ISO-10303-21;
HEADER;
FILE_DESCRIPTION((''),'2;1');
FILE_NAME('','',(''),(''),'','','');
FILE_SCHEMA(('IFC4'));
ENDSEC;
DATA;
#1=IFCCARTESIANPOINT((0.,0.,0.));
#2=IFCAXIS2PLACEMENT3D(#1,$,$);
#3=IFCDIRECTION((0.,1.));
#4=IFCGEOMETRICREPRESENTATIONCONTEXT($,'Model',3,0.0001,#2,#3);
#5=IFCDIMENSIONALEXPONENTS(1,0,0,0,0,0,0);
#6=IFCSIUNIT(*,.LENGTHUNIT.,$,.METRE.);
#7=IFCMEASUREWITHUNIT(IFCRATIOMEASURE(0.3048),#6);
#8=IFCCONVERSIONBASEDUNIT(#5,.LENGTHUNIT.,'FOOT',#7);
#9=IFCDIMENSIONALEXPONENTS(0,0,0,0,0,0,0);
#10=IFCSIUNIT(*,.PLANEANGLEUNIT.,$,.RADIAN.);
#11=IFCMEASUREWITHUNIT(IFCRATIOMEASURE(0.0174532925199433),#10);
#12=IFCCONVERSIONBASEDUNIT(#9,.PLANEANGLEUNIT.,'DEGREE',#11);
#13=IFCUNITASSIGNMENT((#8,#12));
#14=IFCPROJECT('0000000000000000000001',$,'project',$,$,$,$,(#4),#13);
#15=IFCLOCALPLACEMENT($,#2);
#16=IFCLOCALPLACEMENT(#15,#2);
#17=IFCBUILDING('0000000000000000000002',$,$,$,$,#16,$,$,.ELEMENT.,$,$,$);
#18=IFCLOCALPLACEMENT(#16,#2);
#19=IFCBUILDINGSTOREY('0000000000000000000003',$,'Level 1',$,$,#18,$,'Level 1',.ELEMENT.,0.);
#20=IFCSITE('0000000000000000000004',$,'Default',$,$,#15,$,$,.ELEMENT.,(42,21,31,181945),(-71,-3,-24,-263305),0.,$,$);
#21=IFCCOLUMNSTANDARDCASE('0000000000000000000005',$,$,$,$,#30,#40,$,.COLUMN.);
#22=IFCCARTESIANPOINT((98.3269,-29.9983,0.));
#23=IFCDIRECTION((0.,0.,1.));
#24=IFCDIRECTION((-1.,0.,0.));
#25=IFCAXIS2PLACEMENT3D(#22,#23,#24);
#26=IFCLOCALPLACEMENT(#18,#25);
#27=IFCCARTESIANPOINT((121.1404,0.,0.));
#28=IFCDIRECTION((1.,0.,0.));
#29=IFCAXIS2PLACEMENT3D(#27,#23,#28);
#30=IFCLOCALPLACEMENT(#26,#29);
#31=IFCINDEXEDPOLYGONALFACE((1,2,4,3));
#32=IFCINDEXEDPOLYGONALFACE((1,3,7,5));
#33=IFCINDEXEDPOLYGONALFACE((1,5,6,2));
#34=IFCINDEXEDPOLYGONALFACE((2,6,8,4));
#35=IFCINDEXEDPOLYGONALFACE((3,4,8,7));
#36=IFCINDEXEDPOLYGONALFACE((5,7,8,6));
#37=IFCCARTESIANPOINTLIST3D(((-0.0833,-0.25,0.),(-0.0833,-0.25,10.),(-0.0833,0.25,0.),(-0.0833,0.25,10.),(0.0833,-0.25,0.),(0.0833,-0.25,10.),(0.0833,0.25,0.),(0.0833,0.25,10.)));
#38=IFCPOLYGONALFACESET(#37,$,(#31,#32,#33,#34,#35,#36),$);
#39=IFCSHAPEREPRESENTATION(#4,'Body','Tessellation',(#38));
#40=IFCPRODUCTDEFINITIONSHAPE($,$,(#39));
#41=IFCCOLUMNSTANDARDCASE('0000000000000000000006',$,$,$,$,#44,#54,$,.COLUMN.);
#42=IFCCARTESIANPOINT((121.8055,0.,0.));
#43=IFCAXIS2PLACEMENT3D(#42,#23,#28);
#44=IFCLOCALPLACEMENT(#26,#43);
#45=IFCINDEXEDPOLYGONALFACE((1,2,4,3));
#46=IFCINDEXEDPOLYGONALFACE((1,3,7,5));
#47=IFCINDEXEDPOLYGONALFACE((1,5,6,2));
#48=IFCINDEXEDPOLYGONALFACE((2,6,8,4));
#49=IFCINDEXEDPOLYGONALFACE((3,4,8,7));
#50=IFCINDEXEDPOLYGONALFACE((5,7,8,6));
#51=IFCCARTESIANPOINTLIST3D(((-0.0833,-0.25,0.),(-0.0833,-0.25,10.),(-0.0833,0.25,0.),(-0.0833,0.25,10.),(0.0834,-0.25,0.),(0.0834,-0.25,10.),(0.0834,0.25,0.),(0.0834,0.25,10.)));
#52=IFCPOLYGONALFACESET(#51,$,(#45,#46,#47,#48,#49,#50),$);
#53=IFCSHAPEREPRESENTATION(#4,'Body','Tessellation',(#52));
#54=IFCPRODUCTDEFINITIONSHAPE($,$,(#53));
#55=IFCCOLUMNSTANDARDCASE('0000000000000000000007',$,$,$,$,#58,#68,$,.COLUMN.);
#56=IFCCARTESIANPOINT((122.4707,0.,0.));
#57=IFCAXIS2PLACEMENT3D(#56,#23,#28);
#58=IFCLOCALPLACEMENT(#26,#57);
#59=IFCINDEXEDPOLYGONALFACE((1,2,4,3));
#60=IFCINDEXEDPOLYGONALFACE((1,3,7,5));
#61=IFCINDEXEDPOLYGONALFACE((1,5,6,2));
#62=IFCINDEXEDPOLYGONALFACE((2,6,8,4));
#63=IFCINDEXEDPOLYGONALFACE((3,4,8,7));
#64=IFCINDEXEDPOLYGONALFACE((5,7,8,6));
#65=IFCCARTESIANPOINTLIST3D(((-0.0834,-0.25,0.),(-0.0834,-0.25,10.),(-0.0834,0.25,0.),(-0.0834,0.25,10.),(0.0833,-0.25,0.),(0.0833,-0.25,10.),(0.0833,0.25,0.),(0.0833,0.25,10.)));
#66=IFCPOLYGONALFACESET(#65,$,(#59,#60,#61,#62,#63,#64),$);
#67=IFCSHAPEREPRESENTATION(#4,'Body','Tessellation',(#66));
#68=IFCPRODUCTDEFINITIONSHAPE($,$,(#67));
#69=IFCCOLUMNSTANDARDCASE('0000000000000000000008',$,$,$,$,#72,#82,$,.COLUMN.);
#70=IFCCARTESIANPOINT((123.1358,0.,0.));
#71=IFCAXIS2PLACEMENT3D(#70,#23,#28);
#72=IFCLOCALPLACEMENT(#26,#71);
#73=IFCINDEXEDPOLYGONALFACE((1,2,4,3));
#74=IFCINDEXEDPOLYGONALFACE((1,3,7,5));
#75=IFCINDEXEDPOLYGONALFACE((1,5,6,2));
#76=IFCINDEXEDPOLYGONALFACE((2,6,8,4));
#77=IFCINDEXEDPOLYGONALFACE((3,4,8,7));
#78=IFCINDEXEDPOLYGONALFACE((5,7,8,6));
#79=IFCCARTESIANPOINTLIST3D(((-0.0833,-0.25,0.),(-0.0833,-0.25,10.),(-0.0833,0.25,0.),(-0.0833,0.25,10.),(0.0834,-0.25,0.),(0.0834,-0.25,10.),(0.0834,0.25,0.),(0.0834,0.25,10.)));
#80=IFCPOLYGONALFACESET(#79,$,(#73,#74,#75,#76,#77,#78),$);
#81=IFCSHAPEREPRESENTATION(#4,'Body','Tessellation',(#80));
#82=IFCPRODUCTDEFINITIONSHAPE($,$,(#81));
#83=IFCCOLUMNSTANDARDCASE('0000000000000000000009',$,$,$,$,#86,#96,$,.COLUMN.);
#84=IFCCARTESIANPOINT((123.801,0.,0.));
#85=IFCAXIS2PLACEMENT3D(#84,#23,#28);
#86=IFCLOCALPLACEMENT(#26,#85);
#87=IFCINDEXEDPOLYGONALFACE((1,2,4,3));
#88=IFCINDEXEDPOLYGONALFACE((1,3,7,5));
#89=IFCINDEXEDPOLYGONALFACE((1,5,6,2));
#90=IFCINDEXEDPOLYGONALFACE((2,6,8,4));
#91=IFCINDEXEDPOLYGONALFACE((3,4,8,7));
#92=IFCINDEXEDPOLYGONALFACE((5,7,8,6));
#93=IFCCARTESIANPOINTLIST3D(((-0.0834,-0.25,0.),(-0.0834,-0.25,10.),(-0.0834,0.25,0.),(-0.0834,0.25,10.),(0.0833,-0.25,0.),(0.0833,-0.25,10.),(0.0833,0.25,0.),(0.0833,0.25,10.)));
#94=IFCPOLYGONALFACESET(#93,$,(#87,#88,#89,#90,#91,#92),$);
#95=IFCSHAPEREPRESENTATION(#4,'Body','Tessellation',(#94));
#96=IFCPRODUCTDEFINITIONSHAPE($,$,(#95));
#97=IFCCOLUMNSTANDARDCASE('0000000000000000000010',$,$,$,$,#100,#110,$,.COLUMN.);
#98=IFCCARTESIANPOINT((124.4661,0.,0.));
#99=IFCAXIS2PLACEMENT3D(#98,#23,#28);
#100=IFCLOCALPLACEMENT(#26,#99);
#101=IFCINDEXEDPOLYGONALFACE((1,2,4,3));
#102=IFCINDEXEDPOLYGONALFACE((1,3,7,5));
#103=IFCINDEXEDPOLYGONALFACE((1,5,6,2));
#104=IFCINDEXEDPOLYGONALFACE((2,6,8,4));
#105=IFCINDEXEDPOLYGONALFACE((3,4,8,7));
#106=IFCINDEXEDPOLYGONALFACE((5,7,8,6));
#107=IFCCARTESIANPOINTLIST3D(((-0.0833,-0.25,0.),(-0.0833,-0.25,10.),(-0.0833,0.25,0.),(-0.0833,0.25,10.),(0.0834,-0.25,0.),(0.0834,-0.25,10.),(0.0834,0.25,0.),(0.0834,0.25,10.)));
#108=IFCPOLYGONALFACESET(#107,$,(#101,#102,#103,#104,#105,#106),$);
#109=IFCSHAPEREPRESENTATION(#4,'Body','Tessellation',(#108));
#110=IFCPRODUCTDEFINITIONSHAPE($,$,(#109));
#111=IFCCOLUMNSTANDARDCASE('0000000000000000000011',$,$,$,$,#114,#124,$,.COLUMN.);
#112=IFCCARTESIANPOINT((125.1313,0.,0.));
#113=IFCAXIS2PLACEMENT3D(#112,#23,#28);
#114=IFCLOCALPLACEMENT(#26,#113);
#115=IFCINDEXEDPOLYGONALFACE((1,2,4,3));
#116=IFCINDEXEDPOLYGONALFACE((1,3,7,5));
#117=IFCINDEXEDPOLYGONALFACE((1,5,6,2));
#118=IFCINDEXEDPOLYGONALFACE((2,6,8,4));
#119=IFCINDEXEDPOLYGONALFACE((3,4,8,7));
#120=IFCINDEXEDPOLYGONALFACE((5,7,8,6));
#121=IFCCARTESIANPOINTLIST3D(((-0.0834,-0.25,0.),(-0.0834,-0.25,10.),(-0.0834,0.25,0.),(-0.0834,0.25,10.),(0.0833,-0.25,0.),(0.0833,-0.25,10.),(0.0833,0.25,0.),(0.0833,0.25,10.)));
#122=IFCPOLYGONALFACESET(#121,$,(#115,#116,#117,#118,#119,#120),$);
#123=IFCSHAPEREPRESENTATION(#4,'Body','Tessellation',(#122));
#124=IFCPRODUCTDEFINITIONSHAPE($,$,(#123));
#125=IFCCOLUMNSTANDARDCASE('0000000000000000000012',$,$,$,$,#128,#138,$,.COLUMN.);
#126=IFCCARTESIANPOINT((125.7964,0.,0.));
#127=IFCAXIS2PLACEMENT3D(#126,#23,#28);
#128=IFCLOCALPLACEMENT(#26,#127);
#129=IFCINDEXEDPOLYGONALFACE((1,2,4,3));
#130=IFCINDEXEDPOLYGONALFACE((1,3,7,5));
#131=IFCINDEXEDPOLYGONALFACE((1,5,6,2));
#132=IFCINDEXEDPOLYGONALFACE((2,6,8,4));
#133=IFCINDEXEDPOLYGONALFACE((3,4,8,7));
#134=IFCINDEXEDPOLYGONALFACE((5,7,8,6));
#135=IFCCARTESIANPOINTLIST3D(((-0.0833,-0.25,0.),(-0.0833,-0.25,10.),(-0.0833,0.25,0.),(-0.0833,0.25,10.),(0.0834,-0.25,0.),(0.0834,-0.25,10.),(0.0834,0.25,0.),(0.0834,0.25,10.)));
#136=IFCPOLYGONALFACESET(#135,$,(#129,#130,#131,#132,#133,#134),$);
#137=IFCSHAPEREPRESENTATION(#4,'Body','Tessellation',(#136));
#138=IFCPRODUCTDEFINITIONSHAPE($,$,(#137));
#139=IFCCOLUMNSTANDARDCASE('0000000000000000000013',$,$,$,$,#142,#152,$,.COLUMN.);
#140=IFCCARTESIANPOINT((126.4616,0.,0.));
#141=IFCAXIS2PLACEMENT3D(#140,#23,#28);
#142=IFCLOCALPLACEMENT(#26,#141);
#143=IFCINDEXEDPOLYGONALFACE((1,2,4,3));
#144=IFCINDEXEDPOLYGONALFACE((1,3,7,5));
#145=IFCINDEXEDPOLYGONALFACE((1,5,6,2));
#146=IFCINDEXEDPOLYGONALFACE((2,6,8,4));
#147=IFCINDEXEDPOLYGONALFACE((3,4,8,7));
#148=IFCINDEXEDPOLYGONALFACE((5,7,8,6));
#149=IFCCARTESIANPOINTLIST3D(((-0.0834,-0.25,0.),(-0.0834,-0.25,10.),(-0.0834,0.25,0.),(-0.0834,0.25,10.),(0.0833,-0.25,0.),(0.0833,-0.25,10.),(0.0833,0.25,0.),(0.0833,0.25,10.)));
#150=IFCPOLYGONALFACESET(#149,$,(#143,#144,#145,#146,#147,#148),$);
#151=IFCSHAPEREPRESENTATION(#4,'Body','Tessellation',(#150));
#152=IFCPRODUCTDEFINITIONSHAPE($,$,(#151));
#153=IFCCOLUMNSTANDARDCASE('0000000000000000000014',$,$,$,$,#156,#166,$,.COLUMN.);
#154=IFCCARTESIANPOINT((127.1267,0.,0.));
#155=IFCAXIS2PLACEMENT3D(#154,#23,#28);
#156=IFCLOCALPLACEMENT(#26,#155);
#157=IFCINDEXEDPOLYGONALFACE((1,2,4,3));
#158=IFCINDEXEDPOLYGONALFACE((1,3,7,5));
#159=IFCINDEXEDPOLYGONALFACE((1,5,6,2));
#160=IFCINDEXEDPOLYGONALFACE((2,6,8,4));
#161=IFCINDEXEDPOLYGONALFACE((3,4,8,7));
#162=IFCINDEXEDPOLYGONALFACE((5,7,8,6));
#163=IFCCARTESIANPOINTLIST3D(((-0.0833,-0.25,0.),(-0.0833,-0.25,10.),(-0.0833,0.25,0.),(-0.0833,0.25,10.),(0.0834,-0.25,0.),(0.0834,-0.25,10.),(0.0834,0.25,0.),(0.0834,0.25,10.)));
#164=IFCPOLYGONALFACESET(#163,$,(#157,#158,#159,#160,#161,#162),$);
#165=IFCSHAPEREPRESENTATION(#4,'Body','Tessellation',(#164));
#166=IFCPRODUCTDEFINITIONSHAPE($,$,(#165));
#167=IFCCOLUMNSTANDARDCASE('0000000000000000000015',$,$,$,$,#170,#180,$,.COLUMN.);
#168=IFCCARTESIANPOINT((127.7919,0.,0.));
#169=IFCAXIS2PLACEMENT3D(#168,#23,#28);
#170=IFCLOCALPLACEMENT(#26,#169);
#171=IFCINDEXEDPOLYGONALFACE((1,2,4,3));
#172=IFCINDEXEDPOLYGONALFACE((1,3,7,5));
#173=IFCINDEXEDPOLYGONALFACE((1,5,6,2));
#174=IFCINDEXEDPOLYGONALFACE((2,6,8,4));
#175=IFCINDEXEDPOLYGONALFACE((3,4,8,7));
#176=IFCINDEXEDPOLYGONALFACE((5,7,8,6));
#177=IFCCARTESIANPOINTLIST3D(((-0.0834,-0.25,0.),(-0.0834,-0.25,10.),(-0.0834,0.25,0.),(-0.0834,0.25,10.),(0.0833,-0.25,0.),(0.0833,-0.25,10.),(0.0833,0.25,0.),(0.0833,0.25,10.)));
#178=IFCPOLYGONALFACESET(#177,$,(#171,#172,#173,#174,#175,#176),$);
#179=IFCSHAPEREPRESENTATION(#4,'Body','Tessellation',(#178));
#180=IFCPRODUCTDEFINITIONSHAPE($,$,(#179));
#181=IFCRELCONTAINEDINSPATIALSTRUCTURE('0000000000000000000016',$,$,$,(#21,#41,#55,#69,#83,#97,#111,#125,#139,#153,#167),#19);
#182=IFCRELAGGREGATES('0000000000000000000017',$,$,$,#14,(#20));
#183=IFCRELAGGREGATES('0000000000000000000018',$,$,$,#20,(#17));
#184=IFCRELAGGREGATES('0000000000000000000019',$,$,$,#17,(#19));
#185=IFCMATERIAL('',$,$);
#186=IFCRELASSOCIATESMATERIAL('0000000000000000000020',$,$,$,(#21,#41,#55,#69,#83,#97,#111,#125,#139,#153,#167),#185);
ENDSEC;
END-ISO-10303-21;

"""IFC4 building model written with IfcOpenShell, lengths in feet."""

from ifc_helpers import new_model, entity, si_unit, converted_unit, direction, frame, origin, place, context, project, spatial, rectangle, extrude, material, element, save


model = new_model("IFC4")

# Units and contexts
model_context = context("Model", 3, precision=0.0001, world=origin(), true_north=direction((0.0, 1.0)))
ifc_project = project(units=[converted_unit("LENGTHUNIT", "FOOT", entity("IfcRatioMeasure", 0.3048), si_unit("LENGTHUNIT", "METRE"), dimensions=[1, 0, 0, 0, 0, 0, 0]), converted_unit("PLANEANGLEUNIT", "DEGREE", entity("IfcRatioMeasure", 0.0174532925199433), si_unit("PLANEANGLEUNIT", "RADIAN"), dimensions=[0, 0, 0, 0, 0, 0, 0])], contexts=[model_context])

# Site, building, storey
site_placement = place(None, origin())
site = spatial("IfcSite", under=ifc_project, at=site_placement, Name="Default", CompositionType="ELEMENT", RefLatitude=(42, 21, 31, 181945), RefLongitude=(-71, -3, -24, -263305), RefElevation=0.0)
building_placement = place(site_placement, origin())
building = spatial("IfcBuilding", under=site, at=building_placement, CompositionType="ELEMENT")
storey_placement = place(building_placement, origin())
storey = spatial("IfcBuildingStorey", under=building, at=storey_placement, Name="Level 1", LongName="Level 1", CompositionType="ELEMENT", Elevation=0.0)

# Columns
ifc_material = material(Name="")
placement = place(storey_placement, frame((98.3269, -29.9983, 0.0), z_axis=(0.0, 0.0, 1.0), x_axis=(-1.0, 0.0, 0.0)))
for number, where, z_axis, x_axis in (
    (1, (121.1404, 0.0, 0.0), (0.0, 0.0, 1.0), (1.0, 0.0, 0.0)),
    (2, (121.8055, 0.0, 0.0), (0.0, 0.0, 1.0), (1.0, 0.0, 0.0)),
    (3, (122.4707, 0.0, 0.0), (0.0, 0.0, 1.0), (1.0, 0.0, 0.0)),
    (4, (123.1358, 0.0, 0.0), (0.0, 0.0, 1.0), (1.0, 0.0, 0.0)),
    (5, (123.801, 0.0, 0.0), (0.0, 0.0, 1.0), (1.0, 0.0, 0.0)),
    (6, (124.4661, 0.0, 0.0), (0.0, 0.0, 1.0), (1.0, 0.0, 0.0)),
    (7, (125.1313, 0.0, 0.0), (0.0, 0.0, 1.0), (1.0, 0.0, 0.0)),
    (8, (125.7964, 0.0, 0.0), (0.0, 0.0, 1.0), (1.0, 0.0, 0.0)),
    (9, (126.4616, 0.0, 0.0), (0.0, 0.0, 1.0), (1.0, 0.0, 0.0)),
    (10, (127.1267, 0.0, 0.0), (0.0, 0.0, 1.0), (1.0, 0.0, 0.0)),
    (11, (127.7919, 0.0, 0.0), (0.0, 0.0, 1.0), (1.0, 0.0, 0.0)),
):
    element("IfcColumnStandardCase", number, at=place(placement, frame(where, z_axis=z_axis, x_axis=x_axis)), inside=storey, material=ifc_material, PredefinedType="COLUMN", context=model_context, shape_type="SweptSolid", body=[
        extrude(rectangle(XDim=0.1667, YDim=0.5), origin(), (0.0, 0.0, 1.0), 10.0),
    ])

save(model, "model.ifc")
